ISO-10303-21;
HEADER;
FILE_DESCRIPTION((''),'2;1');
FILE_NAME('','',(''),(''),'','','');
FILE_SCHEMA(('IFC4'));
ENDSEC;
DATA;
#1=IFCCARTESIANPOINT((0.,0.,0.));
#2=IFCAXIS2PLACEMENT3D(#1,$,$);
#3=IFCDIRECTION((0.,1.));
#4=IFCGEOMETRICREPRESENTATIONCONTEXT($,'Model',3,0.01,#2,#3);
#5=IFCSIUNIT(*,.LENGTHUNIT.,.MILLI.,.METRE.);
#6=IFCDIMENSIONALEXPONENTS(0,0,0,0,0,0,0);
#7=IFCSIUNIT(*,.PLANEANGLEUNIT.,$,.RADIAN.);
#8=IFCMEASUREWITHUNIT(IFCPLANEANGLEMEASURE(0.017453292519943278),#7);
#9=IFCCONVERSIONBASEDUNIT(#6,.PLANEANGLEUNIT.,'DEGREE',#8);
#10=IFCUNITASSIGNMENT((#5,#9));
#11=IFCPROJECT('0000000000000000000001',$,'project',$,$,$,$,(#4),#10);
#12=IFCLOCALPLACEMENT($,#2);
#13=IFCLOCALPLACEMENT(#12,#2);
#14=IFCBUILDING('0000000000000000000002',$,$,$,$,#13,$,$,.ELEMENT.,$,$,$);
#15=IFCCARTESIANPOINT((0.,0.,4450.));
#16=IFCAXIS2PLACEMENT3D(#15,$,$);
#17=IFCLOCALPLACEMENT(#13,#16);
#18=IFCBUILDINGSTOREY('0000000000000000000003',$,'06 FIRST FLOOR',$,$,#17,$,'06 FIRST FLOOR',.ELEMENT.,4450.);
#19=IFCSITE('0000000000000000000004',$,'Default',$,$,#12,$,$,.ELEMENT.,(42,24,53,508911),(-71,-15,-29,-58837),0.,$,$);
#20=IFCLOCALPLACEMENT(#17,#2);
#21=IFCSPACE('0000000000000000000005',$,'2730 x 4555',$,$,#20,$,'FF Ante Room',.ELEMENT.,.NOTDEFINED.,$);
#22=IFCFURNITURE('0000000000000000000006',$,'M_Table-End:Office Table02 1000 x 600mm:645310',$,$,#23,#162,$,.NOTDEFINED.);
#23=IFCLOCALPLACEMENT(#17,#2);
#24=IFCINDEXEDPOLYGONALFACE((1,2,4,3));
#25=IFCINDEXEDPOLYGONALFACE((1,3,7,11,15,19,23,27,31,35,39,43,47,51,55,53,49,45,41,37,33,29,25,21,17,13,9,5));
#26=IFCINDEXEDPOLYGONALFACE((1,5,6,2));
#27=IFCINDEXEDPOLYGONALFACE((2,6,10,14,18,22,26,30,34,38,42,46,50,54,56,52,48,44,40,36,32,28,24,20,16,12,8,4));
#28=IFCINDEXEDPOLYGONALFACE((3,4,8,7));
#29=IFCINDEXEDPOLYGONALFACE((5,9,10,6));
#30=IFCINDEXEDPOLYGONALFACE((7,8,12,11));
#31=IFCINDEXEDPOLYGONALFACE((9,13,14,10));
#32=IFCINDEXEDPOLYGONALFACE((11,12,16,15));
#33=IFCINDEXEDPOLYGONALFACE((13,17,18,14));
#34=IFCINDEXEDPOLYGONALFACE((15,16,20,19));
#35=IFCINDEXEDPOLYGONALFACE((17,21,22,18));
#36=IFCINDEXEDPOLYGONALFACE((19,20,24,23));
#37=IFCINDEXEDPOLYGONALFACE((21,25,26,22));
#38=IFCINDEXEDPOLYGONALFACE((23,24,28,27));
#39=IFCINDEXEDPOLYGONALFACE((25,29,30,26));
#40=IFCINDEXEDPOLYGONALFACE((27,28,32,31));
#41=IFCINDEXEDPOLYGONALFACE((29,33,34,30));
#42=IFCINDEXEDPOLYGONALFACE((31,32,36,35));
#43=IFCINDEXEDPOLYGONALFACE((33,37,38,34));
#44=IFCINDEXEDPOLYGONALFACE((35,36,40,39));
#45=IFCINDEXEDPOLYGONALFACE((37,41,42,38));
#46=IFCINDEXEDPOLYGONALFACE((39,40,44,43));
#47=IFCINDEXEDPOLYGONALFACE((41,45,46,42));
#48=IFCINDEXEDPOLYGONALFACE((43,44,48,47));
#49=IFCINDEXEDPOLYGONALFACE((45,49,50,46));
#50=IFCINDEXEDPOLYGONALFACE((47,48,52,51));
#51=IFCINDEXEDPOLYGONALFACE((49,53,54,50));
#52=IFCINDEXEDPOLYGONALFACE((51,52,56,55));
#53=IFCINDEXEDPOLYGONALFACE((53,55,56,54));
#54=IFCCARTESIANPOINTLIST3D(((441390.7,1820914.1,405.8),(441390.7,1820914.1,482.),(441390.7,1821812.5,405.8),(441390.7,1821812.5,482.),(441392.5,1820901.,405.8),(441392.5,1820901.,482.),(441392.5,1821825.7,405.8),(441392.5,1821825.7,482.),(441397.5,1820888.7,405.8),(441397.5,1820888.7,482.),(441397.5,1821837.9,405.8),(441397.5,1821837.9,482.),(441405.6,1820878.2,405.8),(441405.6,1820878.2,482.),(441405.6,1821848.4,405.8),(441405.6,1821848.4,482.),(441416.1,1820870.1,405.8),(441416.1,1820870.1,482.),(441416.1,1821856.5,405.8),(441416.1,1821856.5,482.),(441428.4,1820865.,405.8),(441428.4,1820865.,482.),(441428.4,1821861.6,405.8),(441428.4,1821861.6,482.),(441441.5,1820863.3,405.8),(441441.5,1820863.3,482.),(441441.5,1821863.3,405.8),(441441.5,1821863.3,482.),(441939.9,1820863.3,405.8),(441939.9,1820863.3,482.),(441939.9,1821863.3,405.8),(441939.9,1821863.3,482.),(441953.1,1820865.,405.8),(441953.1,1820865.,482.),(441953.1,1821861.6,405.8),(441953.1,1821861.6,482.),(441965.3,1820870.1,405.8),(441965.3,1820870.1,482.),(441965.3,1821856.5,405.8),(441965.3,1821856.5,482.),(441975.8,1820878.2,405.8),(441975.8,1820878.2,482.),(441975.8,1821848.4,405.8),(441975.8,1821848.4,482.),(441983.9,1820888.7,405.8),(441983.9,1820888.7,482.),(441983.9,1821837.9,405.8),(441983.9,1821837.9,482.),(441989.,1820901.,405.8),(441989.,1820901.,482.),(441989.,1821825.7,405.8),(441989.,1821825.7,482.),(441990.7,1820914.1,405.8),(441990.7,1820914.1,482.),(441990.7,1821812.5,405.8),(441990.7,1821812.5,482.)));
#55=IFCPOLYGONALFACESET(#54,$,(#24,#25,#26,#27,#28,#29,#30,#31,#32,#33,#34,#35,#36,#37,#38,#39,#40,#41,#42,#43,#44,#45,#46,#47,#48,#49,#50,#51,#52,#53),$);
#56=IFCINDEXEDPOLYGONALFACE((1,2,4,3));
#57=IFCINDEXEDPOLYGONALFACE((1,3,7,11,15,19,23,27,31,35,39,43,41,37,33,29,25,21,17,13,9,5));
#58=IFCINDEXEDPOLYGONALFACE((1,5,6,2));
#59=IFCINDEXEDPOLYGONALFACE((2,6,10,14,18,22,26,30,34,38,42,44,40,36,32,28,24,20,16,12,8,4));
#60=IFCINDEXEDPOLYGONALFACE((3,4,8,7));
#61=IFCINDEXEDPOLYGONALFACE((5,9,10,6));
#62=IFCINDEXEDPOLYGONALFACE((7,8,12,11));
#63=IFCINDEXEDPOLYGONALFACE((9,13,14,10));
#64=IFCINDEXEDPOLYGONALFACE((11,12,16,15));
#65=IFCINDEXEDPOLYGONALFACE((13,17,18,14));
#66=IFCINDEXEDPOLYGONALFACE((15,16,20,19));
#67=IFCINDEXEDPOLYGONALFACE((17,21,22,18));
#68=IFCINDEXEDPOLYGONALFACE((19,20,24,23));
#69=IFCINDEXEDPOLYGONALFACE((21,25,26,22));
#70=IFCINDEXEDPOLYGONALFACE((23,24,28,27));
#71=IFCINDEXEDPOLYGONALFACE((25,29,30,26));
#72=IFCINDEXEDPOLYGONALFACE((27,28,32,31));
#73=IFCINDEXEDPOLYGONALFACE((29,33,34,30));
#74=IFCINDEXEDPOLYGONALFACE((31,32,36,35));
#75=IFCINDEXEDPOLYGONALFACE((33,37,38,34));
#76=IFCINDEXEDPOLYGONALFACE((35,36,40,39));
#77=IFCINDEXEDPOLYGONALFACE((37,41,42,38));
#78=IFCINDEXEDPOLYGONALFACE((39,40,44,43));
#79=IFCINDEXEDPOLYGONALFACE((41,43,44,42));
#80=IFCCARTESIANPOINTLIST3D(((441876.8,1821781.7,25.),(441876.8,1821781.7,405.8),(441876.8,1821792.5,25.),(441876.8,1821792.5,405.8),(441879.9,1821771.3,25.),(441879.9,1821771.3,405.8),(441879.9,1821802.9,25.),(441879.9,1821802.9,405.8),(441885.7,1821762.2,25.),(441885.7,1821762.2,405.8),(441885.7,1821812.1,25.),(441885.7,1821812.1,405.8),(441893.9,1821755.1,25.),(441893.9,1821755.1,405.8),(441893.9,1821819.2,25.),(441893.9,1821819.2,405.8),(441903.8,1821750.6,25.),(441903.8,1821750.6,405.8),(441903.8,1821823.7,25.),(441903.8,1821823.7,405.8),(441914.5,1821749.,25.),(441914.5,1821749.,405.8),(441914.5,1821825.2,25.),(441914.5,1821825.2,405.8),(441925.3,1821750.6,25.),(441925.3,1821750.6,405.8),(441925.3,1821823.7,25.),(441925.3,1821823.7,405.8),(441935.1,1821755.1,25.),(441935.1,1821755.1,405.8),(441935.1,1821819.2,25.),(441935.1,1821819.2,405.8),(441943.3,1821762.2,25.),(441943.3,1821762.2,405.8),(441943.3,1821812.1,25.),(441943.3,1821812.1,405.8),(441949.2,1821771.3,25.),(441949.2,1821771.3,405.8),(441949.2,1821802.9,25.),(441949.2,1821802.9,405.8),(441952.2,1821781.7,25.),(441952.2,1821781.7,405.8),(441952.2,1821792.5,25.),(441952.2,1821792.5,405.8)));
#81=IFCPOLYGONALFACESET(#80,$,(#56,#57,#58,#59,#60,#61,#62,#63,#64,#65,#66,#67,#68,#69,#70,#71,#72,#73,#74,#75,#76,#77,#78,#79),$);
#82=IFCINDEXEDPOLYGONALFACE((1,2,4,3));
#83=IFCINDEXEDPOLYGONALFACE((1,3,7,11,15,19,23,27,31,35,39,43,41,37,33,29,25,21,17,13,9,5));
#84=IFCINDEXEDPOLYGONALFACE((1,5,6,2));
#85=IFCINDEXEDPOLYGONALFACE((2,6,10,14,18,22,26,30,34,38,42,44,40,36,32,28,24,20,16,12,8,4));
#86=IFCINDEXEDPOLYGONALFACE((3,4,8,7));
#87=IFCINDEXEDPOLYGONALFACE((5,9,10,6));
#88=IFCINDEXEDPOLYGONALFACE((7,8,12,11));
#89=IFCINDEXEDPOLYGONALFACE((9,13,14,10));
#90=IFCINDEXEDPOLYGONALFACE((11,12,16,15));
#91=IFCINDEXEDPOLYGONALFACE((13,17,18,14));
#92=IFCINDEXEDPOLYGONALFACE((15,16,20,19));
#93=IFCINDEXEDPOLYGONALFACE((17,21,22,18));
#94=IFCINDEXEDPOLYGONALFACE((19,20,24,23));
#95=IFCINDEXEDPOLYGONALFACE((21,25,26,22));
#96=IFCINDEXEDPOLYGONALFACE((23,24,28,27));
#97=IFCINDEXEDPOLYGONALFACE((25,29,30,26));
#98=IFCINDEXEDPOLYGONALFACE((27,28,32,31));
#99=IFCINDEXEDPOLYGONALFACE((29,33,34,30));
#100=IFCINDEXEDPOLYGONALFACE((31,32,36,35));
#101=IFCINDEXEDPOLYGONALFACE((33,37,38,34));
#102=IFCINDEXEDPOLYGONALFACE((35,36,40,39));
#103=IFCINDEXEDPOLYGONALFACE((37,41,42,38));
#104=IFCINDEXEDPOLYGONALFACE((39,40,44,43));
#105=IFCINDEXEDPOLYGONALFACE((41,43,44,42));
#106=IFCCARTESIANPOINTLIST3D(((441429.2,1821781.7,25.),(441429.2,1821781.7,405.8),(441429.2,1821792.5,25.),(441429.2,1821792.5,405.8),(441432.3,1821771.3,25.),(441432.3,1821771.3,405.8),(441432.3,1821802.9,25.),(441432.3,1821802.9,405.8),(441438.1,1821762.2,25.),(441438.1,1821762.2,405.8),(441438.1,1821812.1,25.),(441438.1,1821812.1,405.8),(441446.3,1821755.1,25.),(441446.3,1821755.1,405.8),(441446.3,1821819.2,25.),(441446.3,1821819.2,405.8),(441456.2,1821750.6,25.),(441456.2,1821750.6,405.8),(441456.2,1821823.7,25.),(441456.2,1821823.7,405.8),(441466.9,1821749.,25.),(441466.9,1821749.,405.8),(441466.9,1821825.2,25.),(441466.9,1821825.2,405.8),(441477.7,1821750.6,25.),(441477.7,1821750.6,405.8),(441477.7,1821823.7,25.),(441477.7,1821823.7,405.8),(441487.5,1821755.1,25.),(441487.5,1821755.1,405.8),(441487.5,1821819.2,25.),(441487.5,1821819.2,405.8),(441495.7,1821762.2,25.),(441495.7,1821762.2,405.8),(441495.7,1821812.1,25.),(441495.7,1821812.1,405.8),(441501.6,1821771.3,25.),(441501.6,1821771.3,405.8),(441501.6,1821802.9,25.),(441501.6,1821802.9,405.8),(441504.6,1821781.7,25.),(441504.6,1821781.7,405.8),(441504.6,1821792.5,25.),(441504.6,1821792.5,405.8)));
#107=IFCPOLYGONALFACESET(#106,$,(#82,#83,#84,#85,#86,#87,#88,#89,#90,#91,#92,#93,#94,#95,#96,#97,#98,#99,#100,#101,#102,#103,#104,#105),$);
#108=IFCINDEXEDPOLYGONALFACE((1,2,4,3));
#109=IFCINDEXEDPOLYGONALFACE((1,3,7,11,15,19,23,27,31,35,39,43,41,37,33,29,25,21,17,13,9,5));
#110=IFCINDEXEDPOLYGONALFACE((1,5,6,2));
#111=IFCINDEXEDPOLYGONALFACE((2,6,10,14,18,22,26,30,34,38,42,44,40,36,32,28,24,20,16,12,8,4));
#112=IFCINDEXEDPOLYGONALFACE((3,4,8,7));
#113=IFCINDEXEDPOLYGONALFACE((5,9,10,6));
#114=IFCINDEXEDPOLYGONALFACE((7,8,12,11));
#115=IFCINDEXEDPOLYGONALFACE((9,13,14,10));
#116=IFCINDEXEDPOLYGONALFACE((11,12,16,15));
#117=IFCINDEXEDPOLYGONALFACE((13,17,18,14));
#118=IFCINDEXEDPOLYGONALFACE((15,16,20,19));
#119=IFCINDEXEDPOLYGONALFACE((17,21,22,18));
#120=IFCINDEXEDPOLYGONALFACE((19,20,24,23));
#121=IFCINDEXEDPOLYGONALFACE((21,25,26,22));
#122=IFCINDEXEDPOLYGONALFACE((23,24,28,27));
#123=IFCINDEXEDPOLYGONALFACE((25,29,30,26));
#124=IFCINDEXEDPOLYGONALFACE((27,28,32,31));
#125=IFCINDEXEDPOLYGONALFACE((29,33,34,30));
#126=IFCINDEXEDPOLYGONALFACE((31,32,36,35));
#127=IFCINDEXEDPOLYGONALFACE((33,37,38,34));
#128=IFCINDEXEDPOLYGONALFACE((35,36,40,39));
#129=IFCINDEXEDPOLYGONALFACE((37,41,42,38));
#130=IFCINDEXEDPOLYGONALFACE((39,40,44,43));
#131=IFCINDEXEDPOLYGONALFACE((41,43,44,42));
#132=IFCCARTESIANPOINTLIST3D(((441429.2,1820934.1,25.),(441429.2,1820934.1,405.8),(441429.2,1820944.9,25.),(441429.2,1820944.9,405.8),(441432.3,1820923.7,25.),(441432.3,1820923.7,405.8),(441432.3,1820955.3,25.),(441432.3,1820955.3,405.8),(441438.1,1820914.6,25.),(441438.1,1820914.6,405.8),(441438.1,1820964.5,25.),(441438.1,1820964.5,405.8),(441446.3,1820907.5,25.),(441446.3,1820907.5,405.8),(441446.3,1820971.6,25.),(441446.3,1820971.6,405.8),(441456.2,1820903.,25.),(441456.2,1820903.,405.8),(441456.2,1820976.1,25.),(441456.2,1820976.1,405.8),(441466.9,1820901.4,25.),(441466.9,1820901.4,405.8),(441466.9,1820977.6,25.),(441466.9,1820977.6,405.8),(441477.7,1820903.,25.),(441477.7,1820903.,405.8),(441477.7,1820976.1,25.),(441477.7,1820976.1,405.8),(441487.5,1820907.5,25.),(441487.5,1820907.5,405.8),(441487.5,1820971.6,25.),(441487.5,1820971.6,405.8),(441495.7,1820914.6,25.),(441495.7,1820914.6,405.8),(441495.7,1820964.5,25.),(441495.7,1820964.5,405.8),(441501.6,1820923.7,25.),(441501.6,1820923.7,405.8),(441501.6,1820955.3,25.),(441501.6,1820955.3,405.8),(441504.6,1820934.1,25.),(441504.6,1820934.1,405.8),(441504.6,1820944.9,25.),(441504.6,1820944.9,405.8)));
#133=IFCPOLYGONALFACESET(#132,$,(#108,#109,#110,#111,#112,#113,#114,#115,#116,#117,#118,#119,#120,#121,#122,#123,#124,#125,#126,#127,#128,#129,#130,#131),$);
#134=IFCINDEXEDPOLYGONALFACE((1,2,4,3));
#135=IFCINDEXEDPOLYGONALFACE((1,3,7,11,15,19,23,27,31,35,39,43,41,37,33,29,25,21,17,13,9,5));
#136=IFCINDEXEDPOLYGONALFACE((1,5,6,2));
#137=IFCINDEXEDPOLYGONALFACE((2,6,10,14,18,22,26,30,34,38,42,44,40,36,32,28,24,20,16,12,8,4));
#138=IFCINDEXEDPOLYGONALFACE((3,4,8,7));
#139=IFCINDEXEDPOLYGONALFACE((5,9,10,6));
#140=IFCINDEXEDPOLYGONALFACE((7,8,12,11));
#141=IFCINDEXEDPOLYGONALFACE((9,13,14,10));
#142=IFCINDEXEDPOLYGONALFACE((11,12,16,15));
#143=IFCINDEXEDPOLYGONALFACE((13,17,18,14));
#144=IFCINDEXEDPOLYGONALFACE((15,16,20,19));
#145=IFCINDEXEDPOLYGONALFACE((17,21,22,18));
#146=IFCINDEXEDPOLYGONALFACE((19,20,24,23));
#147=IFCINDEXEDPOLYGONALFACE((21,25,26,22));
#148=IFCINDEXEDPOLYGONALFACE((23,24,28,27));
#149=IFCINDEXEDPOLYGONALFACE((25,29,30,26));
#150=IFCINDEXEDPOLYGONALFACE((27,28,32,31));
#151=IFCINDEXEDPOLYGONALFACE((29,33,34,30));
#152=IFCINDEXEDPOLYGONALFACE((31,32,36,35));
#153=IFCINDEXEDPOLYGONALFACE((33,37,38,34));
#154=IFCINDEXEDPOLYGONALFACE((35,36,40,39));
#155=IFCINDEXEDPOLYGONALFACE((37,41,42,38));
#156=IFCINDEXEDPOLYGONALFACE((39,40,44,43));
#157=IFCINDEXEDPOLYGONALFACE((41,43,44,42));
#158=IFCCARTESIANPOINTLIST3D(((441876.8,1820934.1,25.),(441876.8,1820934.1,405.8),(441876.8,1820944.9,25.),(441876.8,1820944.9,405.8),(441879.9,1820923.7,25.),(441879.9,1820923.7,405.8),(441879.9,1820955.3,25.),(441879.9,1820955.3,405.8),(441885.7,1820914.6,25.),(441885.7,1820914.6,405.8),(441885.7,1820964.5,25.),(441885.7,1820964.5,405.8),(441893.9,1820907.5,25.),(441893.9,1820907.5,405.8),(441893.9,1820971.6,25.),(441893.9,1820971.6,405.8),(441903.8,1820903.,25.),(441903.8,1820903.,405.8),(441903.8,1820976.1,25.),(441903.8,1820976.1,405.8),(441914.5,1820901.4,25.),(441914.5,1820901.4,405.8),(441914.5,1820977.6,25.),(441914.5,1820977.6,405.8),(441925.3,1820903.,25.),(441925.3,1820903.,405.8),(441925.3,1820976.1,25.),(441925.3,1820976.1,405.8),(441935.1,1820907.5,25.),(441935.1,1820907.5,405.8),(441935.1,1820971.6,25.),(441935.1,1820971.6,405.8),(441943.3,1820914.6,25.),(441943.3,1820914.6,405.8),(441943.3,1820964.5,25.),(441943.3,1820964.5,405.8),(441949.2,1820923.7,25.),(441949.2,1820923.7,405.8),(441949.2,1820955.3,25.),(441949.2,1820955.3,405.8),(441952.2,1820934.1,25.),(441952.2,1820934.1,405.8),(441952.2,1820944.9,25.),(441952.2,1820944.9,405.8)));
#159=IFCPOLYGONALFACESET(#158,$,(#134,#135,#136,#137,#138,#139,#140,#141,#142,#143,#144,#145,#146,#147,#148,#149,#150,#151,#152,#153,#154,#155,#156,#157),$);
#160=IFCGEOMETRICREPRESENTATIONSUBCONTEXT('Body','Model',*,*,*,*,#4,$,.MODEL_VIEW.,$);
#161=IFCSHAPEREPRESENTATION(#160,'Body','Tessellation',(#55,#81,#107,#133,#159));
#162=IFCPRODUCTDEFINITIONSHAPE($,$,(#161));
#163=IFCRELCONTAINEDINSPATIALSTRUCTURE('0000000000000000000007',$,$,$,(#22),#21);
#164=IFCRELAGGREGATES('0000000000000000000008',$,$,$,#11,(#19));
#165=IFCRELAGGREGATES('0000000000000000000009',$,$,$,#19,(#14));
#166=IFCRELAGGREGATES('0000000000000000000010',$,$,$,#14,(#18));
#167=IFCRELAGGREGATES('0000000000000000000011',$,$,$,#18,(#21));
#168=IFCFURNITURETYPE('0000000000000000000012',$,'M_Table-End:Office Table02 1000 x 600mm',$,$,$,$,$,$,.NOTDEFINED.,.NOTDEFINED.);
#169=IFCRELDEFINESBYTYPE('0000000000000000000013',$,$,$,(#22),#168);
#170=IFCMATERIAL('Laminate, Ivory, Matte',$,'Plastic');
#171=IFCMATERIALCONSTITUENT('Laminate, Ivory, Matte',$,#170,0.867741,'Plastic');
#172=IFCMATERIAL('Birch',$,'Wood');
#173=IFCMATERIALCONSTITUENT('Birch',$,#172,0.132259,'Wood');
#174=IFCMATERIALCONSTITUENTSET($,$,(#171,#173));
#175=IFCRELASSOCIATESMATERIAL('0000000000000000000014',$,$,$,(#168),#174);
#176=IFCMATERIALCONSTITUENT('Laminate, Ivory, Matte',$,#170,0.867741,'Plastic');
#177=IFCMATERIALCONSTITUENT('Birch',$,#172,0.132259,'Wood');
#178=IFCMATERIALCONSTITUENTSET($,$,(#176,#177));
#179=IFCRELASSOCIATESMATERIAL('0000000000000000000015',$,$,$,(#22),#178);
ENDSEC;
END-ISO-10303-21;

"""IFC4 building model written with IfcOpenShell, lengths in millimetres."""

from ifc_helpers import new_model, entity, si_unit, converted_unit, direction, frame, origin, place, context, subcontext, project, spatial, line, arc, indexed_curve, outline, extrude, source, transform, mapped, material, constituent, constituent_set, type_object, type_shapes, element, save


model = new_model("IFC4")

# Units and contexts
model_context = context("Model", 3, precision=0.01, world=origin(), true_north=direction((0.0, 1.0)))
body_context = subcontext(model_context, "Body", "Model", "MODEL_VIEW")
ifc_project = project(units=[si_unit("LENGTHUNIT", "METRE", prefix="MILLI"), converted_unit("PLANEANGLEUNIT", "DEGREE", entity("IfcPlaneAngleMeasure", 0.017453292519943278), si_unit("PLANEANGLEUNIT", "RADIAN"), dimensions=[0, 0, 0, 0, 0, 0, 0])], contexts=[model_context])

# Site, building, storey
site_placement = place(None, origin())
site = spatial("IfcSite", under=ifc_project, at=site_placement, Name="Default", CompositionType="ELEMENT", RefLatitude=(42, 24, 53, 508911), RefLongitude=(-71, -15, -29, -58837), RefElevation=0.0)
building_placement = place(site_placement, origin())
building = spatial("IfcBuilding", under=site, at=building_placement, CompositionType="ELEMENT")
storey_placement = place(building_placement, frame((0.0, 0.0, 4450.0)))
storey = spatial("IfcBuildingStorey", under=building, at=storey_placement, Name="06 FIRST FLOOR", LongName="06 FIRST FLOOR", CompositionType="ELEMENT", Elevation=4450.0)

# Shared definitions
space_placement = place(storey_placement, origin())
space = spatial("IfcSpace", under=storey, at=space_placement, Name="2730 x 4555", LongName="FF Ante Room", CompositionType="ELEMENT", PredefinedType="NOTDEFINED")

# Furniture
ifc_material_1 = material(Name="Laminate, Ivory, Matte", Category="Plastic")
ifc_constituent_1 = constituent(ifc_material_1, Name="Laminate, Ivory, Matte", Category="Plastic", fraction=0.867741)
ifc_material_2 = material(Name="Birch", Category="Wood")
ifc_constituent_2 = constituent(ifc_material_2, Name="Birch", Category="Wood", fraction=0.132259)
ifc_constituent_set_1 = constituent_set(constituents=[ifc_constituent_1, ifc_constituent_2])
ifc_constituent_3 = constituent(ifc_material_1, Name="Laminate, Ivory, Matte", Category="Plastic", fraction=0.867741)
ifc_constituent_4 = constituent(ifc_material_2, Name="Birch", Category="Wood", fraction=0.132259)
ifc_constituent_set_2 = constituent_set(constituents=[ifc_constituent_3, ifc_constituent_4])
furniture_type_1 = type_object("IfcFurnitureType", Name="M_Table-End:Office Table02 1000 x 600mm", AssemblyPlace="NOTDEFINED", PredefinedType="NOTDEFINED", material=ifc_constituent_set_2)
shared_shape_1 = source(origin(), body_context, "Body", "SweptSolid", [
    extrude(outline(indexed_curve([(449.2, -300.0), (485.1, -285.1), (500.0, -249.2), (500.0, 249.2), (485.1, 285.1), (449.2, 300.0), (-449.2, 300.0), (-485.1, 285.1), (-500.0, 249.2), (-500.0, -249.2), (-485.1, -285.1), (-449.2, -300.0)], segments=[arc(1, 2, 3), line(3, 4), arc(4, 5, 6), line(6, 7), arc(7, 8, 9), line(9, 10), arc(10, 11, 12), line(12, 1)], self_intersect=False)), frame((503.7, 152.4, 405.8)), (0.0, 0.0, 1.0), 76.2),
    extrude(outline(indexed_curve([(-38.1, 0.0), (0.0, -38.1), (38.1, 0.0), (0.0, 38.1)], segments=[arc(1, 2, 3), arc(3, 4, 1)], self_intersect=False)), frame((927.5, -71.4, 25.0)), (0.0, 0.0, 1.0), 380.8),
    extrude(outline(indexed_curve([(-38.1, 0.0), (0.0, -38.1), (38.1, 0.0), (0.0, 38.1)], segments=[arc(1, 2, 3), arc(3, 4, 1)], self_intersect=False)), frame((927.5, 376.2, 25.0)), (0.0, 0.0, 1.0), 380.8),
    extrude(outline(indexed_curve([(-38.1, 0.0), (0.0, -38.1), (38.1, 0.0), (0.0, 38.1)], segments=[arc(1, 2, 3), arc(3, 4, 1)], self_intersect=False)), frame((79.9, 376.2, 25.0)), (0.0, 0.0, 1.0), 380.8),
    extrude(outline(indexed_curve([(-38.1, 0.0), (0.0, -38.1), (38.1, 0.0), (0.0, 38.1)], segments=[arc(1, 2, 3), arc(3, 4, 1)], self_intersect=False)), frame((79.9, -71.4, 25.0)), (0.0, 0.0, 1.0), 380.8),
])
type_shapes(furniture_type_1, [shared_shape_1])
furniture_1_placement = place(space_placement, frame((441843.1, 1820859.6, 0.0), z_axis=(0.0, 0.0, 1.0), x_axis=(0.0, 1.0, 0.0)))
element("IfcFurniture", 1, at=furniture_1_placement, inside=space, type_object=furniture_type_1, material=ifc_constituent_set_1, Name="M_Table-End:Office Table02 1000 x 600mm:645310", PredefinedType="NOTDEFINED", context=body_context, shape_type="MappedRepresentation", body=[
    mapped(shared_shape_1, transform((0.0, 0.0, 0.0), scale=1.0)),
])

save(model, "model.ifc")
